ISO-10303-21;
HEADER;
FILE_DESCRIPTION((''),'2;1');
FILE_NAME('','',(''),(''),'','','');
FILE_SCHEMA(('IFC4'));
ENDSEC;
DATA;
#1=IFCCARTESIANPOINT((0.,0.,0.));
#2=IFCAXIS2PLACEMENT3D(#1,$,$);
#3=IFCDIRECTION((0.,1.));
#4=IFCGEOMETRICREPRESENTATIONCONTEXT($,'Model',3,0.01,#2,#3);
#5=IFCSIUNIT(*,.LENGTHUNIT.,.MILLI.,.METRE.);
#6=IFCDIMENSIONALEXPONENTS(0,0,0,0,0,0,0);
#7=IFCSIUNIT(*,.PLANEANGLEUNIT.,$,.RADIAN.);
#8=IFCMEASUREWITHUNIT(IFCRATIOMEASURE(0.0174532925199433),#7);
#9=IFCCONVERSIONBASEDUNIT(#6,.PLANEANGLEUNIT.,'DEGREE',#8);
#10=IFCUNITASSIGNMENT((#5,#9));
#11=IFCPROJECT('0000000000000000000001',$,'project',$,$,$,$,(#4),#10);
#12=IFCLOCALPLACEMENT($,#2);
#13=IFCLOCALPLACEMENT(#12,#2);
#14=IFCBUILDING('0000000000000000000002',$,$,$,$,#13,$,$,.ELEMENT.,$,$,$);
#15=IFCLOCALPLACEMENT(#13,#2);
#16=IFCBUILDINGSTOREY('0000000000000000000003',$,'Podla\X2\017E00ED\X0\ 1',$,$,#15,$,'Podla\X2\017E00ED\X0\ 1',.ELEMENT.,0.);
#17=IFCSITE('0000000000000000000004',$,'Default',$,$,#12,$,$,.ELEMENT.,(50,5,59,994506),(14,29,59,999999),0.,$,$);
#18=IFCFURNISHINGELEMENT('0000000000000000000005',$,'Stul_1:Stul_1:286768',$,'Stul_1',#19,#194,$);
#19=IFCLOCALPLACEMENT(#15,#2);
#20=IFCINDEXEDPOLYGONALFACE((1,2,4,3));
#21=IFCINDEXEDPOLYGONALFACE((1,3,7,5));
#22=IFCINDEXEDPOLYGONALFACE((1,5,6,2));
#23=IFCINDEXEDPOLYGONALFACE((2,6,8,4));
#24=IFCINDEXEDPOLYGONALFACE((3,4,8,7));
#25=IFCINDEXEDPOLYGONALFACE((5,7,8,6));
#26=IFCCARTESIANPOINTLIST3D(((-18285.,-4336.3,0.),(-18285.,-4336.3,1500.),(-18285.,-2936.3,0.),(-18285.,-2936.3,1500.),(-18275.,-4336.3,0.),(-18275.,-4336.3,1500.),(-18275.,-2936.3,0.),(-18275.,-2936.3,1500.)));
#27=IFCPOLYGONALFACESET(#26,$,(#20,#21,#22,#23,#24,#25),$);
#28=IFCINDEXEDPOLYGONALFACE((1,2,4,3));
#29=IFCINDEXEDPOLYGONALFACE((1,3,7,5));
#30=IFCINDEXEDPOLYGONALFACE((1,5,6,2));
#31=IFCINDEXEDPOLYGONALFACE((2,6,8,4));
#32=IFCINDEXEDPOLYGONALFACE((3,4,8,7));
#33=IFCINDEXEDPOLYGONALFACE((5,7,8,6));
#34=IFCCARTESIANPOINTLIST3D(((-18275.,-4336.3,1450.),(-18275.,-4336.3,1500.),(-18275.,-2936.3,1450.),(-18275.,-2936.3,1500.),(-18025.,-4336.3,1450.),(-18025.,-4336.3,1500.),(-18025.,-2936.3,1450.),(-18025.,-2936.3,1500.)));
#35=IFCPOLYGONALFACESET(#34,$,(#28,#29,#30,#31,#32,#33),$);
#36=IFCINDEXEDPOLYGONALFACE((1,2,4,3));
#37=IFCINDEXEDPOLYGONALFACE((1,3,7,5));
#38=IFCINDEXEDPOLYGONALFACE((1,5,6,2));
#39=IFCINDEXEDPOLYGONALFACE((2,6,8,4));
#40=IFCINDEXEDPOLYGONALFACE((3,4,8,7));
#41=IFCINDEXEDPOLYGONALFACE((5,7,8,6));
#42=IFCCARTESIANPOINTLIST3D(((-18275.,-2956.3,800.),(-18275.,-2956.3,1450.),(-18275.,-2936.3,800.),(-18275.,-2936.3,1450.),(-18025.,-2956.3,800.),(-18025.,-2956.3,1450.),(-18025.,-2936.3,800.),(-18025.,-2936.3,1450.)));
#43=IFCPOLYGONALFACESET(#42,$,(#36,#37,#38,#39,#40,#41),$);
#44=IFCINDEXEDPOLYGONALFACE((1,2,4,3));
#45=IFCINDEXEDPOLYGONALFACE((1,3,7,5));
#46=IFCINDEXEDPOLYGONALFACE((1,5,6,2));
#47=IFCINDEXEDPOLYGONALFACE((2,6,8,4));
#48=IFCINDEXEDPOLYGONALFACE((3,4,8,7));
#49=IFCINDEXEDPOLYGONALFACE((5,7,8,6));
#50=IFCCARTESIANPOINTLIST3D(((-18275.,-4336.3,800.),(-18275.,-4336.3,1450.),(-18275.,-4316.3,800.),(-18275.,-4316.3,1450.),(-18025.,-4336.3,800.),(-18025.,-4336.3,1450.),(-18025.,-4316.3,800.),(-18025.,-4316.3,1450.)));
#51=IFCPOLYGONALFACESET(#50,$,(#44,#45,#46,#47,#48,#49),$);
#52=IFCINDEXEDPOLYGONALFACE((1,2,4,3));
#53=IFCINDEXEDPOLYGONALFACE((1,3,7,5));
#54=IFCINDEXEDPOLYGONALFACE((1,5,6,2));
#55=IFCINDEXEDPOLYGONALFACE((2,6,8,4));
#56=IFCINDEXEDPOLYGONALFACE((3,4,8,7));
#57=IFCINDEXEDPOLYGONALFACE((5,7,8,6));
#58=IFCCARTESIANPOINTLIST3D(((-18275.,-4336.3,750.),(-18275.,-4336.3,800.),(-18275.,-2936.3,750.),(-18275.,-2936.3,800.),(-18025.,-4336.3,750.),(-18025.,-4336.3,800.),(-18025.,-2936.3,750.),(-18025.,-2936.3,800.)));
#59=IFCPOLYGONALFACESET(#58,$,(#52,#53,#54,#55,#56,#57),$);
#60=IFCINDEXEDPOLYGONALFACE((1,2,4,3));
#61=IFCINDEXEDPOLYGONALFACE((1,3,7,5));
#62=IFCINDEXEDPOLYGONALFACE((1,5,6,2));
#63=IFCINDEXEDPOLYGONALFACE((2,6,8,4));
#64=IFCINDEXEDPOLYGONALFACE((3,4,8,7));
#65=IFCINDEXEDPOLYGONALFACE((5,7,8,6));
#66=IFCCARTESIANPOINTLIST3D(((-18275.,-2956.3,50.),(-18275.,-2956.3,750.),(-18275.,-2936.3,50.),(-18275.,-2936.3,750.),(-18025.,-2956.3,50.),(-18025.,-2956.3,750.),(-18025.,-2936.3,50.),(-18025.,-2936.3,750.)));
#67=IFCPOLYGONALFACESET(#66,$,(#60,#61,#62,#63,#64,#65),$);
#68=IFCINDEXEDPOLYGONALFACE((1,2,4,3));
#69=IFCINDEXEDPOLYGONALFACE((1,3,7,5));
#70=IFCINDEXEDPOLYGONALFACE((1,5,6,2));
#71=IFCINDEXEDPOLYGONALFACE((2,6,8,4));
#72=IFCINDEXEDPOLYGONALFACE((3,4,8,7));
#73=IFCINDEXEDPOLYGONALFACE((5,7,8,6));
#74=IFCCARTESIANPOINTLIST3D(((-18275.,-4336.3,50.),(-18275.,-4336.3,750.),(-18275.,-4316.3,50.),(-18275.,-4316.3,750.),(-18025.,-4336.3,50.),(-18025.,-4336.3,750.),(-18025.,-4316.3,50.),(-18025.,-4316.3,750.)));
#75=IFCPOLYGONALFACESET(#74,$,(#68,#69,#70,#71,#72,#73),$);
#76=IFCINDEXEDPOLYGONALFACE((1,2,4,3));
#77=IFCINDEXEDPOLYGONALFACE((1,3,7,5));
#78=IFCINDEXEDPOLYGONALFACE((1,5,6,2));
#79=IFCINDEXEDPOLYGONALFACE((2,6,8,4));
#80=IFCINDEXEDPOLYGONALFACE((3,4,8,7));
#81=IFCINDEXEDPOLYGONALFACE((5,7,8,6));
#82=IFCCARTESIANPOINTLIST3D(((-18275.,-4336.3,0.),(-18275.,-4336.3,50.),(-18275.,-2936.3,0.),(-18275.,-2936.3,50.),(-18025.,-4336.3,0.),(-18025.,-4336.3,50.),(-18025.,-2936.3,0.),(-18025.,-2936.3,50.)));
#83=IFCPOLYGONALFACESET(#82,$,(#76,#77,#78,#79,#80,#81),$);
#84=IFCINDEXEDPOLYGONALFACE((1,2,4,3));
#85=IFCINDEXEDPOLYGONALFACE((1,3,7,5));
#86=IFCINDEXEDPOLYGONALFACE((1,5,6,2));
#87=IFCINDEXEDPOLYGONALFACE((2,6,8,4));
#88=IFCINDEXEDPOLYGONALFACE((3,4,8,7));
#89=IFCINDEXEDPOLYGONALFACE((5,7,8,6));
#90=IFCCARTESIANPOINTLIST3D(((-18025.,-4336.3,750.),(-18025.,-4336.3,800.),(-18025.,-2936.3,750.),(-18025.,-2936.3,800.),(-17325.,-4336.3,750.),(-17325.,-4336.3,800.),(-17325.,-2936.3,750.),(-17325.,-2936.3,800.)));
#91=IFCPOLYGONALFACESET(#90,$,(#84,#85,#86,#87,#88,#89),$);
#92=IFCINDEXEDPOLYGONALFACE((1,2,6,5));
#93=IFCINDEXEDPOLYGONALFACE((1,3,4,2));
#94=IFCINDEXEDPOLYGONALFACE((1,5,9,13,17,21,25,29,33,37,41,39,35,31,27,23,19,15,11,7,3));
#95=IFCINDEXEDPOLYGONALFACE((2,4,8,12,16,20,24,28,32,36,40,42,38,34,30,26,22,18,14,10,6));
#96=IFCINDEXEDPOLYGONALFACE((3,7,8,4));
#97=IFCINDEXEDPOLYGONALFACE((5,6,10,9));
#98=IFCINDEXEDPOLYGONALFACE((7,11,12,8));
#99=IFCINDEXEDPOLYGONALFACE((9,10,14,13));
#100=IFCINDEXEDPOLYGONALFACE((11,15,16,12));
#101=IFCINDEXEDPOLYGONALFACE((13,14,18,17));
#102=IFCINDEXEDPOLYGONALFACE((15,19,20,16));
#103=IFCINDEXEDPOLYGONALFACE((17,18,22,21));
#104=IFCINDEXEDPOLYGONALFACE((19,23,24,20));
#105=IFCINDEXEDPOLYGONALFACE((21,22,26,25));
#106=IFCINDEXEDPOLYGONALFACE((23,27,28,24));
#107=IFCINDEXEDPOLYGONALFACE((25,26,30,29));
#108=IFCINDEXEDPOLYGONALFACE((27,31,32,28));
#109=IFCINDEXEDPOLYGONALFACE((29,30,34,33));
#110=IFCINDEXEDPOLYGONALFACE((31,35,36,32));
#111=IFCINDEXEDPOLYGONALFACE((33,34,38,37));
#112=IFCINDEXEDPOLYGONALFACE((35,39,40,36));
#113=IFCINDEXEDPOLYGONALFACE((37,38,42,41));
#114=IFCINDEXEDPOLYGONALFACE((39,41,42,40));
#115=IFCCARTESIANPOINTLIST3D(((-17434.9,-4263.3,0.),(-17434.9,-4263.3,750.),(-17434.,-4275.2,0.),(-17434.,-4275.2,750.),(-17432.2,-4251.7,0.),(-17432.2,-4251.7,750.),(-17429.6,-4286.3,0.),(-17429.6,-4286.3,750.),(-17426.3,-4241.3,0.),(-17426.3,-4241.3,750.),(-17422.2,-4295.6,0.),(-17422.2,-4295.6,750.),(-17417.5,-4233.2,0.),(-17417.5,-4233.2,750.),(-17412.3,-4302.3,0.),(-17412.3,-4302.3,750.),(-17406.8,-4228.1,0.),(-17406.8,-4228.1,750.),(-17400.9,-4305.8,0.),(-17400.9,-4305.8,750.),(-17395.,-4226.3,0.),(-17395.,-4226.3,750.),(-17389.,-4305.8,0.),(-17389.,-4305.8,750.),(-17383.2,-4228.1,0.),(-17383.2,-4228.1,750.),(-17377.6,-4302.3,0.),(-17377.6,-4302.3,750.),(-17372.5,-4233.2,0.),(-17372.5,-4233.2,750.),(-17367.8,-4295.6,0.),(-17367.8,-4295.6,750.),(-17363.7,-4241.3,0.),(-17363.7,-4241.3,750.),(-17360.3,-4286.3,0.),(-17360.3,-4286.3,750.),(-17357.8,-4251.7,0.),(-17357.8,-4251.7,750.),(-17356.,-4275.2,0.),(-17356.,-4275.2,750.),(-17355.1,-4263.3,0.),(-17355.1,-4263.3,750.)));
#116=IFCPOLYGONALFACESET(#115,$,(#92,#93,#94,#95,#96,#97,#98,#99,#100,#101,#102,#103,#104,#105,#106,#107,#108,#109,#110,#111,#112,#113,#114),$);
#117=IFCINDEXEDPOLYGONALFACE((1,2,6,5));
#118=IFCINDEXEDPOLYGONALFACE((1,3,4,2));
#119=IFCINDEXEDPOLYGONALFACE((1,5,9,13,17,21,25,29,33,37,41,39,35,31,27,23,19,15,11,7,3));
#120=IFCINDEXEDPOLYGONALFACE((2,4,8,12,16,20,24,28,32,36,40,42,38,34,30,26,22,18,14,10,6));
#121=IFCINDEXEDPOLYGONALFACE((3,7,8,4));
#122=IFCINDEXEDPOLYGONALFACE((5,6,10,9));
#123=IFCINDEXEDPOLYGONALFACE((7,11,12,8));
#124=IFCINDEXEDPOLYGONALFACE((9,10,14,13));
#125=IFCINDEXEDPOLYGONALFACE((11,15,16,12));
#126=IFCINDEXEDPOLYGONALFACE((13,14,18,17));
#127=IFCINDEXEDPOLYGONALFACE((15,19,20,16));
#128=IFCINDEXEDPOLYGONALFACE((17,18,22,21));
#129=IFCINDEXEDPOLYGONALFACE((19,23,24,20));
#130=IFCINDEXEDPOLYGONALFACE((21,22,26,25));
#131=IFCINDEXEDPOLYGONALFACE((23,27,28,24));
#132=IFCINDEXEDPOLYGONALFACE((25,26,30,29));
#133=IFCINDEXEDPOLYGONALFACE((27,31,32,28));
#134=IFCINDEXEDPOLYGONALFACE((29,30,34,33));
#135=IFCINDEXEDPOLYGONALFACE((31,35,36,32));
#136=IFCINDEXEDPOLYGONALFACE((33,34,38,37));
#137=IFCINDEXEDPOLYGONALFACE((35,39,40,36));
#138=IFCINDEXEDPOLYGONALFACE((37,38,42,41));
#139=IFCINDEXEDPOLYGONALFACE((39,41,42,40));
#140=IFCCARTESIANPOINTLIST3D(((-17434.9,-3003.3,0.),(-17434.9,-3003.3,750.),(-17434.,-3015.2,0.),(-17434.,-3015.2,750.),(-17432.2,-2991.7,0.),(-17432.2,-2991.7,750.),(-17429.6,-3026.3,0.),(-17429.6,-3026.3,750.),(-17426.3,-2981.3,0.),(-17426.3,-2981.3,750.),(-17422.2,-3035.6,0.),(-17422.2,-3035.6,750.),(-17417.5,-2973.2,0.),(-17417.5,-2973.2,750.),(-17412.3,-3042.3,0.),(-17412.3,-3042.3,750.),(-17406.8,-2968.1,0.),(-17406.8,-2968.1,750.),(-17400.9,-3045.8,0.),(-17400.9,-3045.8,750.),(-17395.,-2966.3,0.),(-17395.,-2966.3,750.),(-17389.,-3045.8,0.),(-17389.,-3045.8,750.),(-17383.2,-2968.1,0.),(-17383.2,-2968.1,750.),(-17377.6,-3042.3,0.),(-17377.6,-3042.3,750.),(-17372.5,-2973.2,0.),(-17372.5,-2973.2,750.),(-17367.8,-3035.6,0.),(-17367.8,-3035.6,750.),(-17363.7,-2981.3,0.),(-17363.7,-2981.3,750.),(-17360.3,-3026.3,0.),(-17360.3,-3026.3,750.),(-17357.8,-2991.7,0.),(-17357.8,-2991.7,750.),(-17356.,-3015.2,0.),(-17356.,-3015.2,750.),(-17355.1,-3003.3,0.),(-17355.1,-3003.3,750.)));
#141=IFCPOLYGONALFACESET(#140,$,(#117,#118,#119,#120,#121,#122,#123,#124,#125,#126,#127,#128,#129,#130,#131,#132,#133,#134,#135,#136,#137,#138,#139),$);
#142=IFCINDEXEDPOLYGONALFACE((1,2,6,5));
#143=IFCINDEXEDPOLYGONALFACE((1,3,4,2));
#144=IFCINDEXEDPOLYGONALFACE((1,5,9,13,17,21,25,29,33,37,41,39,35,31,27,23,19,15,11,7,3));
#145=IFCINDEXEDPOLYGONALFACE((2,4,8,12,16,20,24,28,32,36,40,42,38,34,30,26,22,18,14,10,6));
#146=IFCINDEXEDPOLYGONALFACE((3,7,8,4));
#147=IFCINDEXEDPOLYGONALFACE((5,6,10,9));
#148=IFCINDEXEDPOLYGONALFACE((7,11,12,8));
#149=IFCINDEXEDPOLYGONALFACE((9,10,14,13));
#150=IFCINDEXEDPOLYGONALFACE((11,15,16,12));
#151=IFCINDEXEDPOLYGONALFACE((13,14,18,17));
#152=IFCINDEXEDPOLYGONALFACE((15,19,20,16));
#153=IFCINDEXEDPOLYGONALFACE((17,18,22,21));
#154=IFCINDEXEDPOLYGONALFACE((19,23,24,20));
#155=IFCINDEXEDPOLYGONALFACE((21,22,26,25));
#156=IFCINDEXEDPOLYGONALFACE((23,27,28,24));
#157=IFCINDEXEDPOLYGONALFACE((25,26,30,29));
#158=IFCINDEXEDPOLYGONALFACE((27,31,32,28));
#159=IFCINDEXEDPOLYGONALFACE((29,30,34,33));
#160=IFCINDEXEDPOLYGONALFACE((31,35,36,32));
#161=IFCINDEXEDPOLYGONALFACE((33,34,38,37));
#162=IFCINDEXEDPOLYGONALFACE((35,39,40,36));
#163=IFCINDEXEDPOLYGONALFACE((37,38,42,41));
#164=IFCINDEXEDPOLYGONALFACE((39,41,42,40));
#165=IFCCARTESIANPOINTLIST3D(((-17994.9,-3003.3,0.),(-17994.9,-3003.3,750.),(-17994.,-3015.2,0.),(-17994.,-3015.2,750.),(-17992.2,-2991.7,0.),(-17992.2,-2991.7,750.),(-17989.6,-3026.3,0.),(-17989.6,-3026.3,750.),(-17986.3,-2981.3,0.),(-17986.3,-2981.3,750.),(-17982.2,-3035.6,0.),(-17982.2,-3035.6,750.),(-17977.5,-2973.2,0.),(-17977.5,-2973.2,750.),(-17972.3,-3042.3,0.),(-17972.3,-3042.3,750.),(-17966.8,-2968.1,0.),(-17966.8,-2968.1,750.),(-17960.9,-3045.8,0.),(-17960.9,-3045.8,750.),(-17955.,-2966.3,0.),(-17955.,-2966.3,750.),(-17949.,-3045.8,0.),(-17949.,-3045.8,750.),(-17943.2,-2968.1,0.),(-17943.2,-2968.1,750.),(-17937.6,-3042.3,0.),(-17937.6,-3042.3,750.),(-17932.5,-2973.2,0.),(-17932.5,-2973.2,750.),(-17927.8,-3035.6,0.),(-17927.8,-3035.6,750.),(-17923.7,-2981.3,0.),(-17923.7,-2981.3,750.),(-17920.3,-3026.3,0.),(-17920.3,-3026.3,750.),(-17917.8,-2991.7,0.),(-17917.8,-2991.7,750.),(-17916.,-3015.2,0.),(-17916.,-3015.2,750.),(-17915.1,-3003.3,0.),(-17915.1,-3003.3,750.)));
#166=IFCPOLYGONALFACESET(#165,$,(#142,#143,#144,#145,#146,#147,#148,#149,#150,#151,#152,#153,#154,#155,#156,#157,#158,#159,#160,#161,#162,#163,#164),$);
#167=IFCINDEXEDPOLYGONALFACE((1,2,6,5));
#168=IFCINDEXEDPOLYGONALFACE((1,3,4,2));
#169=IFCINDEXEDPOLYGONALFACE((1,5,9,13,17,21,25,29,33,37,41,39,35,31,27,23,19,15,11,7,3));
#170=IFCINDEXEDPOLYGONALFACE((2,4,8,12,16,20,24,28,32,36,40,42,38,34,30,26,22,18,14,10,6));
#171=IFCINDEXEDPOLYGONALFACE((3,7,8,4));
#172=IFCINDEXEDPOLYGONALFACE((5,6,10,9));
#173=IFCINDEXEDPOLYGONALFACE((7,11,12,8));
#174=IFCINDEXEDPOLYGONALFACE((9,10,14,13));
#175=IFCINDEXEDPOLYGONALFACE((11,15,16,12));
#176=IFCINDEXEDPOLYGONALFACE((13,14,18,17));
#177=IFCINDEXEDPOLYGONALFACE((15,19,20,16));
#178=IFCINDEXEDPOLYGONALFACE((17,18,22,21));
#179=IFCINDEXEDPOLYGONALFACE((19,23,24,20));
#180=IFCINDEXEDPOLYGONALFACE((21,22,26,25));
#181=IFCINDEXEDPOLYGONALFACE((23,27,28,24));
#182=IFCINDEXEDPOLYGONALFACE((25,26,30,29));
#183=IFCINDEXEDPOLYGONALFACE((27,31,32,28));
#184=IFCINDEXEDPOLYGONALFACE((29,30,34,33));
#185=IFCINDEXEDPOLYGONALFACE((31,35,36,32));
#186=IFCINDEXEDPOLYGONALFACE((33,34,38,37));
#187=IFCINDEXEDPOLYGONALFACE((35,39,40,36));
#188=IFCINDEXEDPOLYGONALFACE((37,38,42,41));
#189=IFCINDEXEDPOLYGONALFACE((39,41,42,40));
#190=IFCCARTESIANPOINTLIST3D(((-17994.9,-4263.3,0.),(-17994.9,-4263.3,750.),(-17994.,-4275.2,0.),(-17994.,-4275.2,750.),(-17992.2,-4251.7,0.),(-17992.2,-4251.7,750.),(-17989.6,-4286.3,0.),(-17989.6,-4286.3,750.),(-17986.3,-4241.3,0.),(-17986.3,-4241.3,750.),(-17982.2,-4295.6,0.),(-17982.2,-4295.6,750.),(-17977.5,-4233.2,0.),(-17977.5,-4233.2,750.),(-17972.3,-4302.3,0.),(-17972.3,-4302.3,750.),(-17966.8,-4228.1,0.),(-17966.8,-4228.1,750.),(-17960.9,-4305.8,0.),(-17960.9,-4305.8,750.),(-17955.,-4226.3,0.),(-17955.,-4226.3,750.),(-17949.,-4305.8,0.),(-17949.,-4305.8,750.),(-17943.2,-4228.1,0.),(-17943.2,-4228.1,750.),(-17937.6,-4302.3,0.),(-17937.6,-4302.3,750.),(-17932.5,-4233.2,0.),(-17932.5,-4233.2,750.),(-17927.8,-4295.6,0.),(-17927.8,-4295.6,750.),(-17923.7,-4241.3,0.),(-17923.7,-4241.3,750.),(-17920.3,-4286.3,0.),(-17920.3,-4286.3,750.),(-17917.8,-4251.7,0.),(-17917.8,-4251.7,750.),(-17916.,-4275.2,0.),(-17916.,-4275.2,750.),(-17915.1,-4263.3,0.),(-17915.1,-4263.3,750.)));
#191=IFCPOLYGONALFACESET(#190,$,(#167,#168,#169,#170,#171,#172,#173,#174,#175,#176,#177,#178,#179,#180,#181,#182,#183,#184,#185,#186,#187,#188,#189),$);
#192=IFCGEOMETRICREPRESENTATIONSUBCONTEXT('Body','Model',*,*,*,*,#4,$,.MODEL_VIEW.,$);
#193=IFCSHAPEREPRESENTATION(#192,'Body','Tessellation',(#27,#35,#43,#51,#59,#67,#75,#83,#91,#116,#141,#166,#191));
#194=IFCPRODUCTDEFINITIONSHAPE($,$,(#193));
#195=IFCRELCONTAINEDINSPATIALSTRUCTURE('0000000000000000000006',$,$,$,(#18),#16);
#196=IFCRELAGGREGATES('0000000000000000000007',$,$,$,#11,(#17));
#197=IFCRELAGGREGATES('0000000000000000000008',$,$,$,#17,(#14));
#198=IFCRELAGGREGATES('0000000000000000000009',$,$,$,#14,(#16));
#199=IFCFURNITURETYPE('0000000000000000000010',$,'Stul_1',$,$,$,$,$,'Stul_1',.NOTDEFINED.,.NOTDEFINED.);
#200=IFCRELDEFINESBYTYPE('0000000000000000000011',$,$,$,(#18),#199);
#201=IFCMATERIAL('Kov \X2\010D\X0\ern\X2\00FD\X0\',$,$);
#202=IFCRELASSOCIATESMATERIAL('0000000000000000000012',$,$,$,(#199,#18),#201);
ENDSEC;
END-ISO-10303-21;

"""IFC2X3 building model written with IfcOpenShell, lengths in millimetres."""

from ifc_helpers import new_model, entity, si_unit, converted_unit, direction, frame, frame_2d, origin, origin_2d_with_axis, place, context, subcontext, project, spatial, rectangle, circle, extrude, source, transform, mapped, material, type_object, type_shapes, element, save


model = new_model("IFC2X3")

# Units and contexts
model_context = context("Model", 3, precision=0.01, world=origin(), true_north=direction((0.0, 1.0)))
body_context = subcontext(model_context, "Body", "Model", "MODEL_VIEW")
ifc_project = project(units=[si_unit("LENGTHUNIT", "METRE", prefix="MILLI"), converted_unit("PLANEANGLEUNIT", "DEGREE", entity("IfcRatioMeasure", 0.0174532925199433), si_unit("PLANEANGLEUNIT", "RADIAN"), dimensions=[0, 0, 0, 0, 0, 0, 0])], contexts=[model_context])

# Site, building, storey
site_placement = place(None, origin())
site = spatial("IfcSite", under=ifc_project, at=site_placement, Name="Default", CompositionType="ELEMENT", RefLatitude=(50, 5, 59, 994506), RefLongitude=(14, 29, 59, 999999), RefElevation=0.0)
building_placement = place(site_placement, origin())
building = spatial("IfcBuilding", under=site, at=building_placement, CompositionType="ELEMENT")
storey_placement = place(building_placement, origin())
storey = spatial("IfcBuildingStorey", under=building, at=storey_placement, Name="Podlaží 1", LongName="Podlaží 1", CompositionType="ELEMENT", Elevation=0.0)

# Furnishing element
ifc_material_1 = material(Name="Kov černý")
furniture_type = type_object("IfcFurnitureType", Name="Stul_1", ElementType="Stul_1", material=ifc_material_1)
shared_shape_1 = source(origin(), body_context, "Body", "SweptSolid", [
    extrude(rectangle(XDim=1400.0, YDim=10.0, at=origin_2d_with_axis()), frame((0.0, 605.0, 0.0), z_axis=(0.0, 0.0, 1.0), x_axis=(-1.0, 0.0, 0.0)), (0.0, 0.0, 1.0), 1500.0),
    extrude(rectangle(XDim=1400.0, YDim=250.0, at=frame_2d((0.0, 0.0), x_axis=(1.0, 0.0))), frame((0.0, 475.0, 1450.0), z_axis=(0.0, 0.0, 1.0), x_axis=(-1.0, 0.0, 0.0)), (0.0, 0.0, 1.0), 50.0),
    extrude(rectangle(XDim=20.0, YDim=250.0, at=origin_2d_with_axis()), frame((690.0, 475.0, 800.0), z_axis=(0.0, 0.0, 1.0), x_axis=(-1.0, 0.0, 0.0)), (0.0, 0.0, 1.0), 650.0),
    extrude(rectangle(XDim=20.0, YDim=250.0, at=frame_2d((0.0, 0.0), x_axis=(1.0, 0.0))), frame((-690.0, 475.0, 800.0), z_axis=(0.0, 0.0, 1.0), x_axis=(-1.0, 0.0, 0.0)), (0.0, 0.0, 1.0), 650.0),
    extrude(rectangle(XDim=1400.0, YDim=250.0, at=origin_2d_with_axis()), frame((0.0, 475.0, 750.0), z_axis=(0.0, 0.0, 1.0), x_axis=(-1.0, 0.0, 0.0)), (0.0, 0.0, 1.0), 50.0),
    extrude(rectangle(XDim=20.0, YDim=250.0, at=origin_2d_with_axis()), frame((690.0, 475.0, 50.0), z_axis=(0.0, 0.0, 1.0), x_axis=(-1.0, 0.0, 0.0)), (0.0, 0.0, 1.0), 700.0),
    extrude(rectangle(XDim=20.0, YDim=250.0, at=frame_2d((0.0, 0.0), x_axis=(1.0, 0.0))), frame((-690.0, 475.0, 50.0), z_axis=(0.0, 0.0, 1.0), x_axis=(-1.0, 0.0, 0.0)), (0.0, 0.0, 1.0), 700.0),
    extrude(rectangle(XDim=1400.0, YDim=250.0, at=origin_2d_with_axis()), frame((0.0, 475.0, 0.0), z_axis=(0.0, 0.0, 1.0), x_axis=(-1.0, 0.0, 0.0)), (0.0, 0.0, 1.0), 50.0),
    extrude(rectangle(XDim=1400.0, YDim=700.0, at=origin_2d_with_axis()), frame((0.0, 0.0, 750.0), z_axis=(0.0, 0.0, 1.0), x_axis=(-1.0, 0.0, 0.0)), (0.0, 0.0, 1.0), 50.0),
    extrude(circle(Radius=40.0, at=frame_2d((0.0, 0.0), x_axis=(1.0, 0.0))), frame((-630.0, -280.0, 0.0)), (0.0, 0.0, 1.0), 750.0),
    extrude(circle(Radius=40.0, at=frame_2d((0.0, 0.0), x_axis=(1.0, 0.0))), frame((630.0, -280.0, 0.0)), (0.0, 0.0, 1.0), 750.0),
    extrude(circle(Radius=40.0, at=frame_2d((0.0, 0.0), x_axis=(1.0, 0.0))), frame((630.0, 280.0, 0.0)), (0.0, 0.0, 1.0), 750.0),
    extrude(circle(Radius=40.0, at=frame_2d((0.0, 0.0), x_axis=(1.0, 0.0))), frame((-630.0, 280.0, 0.0)), (0.0, 0.0, 1.0), 750.0),
])
type_shapes(furniture_type, [shared_shape_1])
for number, where, z_axis, x_axis, name in (
    (1, (-17675.0, -3636.3, 0.0), (0.0, 0.0, 1.0), (0.0, 1.0, 0.0), "Stul_1:Stul_1:286768"),
):
    element("IfcFurnishingElement", number, at=place(storey_placement, frame(where, z_axis=z_axis, x_axis=x_axis)), inside=storey, type_object=furniture_type, material=ifc_material_1, Name=name, ObjectType="Stul_1", context=body_context, shape_type="MappedRepresentation", body=[
        mapped(shared_shape_1, transform((0.0, 0.0, 0.0), scale=1.0)),
    ])

save(model, "model.ifc")
